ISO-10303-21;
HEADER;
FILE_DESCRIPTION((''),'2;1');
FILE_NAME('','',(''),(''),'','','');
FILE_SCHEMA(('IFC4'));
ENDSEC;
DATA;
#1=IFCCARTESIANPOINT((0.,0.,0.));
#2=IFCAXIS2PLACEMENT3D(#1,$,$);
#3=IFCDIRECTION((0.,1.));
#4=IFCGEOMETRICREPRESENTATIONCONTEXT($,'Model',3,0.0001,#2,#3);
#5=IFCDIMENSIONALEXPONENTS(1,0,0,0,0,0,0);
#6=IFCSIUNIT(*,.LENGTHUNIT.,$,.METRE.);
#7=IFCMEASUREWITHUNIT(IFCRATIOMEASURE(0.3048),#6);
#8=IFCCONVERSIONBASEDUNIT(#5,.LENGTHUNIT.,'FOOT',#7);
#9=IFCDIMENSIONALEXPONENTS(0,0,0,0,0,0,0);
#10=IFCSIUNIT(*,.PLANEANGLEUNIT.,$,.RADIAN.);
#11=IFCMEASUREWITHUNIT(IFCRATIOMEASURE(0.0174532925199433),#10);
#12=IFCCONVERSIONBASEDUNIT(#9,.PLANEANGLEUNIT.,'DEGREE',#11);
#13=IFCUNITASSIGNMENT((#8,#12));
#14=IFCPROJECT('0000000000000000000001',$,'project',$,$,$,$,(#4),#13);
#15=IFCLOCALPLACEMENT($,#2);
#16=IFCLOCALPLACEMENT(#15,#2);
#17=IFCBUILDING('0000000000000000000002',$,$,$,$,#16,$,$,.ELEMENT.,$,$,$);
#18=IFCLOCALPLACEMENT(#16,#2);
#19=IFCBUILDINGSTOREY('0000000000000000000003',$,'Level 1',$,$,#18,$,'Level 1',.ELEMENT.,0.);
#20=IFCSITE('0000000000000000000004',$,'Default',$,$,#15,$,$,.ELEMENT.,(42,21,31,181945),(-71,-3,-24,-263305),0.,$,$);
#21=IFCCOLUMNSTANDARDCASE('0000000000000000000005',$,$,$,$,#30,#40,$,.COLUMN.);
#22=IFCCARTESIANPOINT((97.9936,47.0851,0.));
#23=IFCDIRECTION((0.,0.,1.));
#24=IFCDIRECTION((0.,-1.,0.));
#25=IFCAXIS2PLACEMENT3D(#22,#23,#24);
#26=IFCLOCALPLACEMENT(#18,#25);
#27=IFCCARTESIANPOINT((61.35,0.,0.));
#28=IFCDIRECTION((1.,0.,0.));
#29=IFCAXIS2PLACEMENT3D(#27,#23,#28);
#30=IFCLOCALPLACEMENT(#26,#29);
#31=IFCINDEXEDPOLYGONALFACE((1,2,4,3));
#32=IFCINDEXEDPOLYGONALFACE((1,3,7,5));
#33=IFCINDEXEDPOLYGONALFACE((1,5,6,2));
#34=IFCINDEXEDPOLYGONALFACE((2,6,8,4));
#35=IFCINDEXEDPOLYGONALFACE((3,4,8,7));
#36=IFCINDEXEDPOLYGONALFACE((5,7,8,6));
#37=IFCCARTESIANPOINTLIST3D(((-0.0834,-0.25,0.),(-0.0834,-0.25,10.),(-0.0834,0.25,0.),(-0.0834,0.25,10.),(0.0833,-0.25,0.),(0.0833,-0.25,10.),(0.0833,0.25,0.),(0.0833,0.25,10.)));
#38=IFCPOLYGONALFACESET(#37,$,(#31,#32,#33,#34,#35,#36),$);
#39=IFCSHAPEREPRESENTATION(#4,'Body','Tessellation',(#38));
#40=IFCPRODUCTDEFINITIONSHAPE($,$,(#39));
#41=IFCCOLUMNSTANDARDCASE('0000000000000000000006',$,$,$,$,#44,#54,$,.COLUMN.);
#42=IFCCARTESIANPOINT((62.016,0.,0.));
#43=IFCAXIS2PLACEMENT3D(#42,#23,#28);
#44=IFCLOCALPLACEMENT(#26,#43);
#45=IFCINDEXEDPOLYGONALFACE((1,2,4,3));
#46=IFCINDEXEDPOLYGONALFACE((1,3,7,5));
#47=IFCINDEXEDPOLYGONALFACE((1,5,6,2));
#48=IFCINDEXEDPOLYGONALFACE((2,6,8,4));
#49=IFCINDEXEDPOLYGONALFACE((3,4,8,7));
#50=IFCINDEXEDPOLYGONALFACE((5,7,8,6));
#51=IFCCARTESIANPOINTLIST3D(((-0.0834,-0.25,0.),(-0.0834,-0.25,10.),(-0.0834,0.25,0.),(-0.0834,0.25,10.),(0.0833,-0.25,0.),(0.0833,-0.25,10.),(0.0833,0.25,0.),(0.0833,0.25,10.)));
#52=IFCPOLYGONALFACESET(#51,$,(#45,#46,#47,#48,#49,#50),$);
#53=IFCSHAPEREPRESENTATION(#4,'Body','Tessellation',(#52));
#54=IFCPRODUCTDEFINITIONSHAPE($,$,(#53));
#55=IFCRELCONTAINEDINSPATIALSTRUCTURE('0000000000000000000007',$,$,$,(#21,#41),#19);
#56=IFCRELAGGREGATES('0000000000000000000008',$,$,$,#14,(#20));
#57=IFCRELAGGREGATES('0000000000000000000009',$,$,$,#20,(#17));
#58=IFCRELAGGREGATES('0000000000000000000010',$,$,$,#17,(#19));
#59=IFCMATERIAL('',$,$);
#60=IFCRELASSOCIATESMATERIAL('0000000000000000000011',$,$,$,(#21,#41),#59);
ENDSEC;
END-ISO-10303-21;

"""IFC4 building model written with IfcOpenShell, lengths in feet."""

from ifc_helpers import new_model, entity, si_unit, converted_unit, direction, frame, origin, place, context, project, spatial, rectangle, extrude, material, element, save


model = new_model("IFC4")

# Units and contexts
model_context = context("Model", 3, precision=0.0001, world=origin(), true_north=direction((0.0, 1.0)))
ifc_project = project(units=[converted_unit("LENGTHUNIT", "FOOT", entity("IfcRatioMeasure", 0.3048), si_unit("LENGTHUNIT", "METRE"), dimensions=[1, 0, 0, 0, 0, 0, 0]), converted_unit("PLANEANGLEUNIT", "DEGREE", entity("IfcRatioMeasure", 0.0174532925199433), si_unit("PLANEANGLEUNIT", "RADIAN"), dimensions=[0, 0, 0, 0, 0, 0, 0])], contexts=[model_context])

# Site, building, storey
site_placement = place(None, origin())
site = spatial("IfcSite", under=ifc_project, at=site_placement, Name="Default", CompositionType="ELEMENT", RefLatitude=(42, 21, 31, 181945), RefLongitude=(-71, -3, -24, -263305), RefElevation=0.0)
building_placement = place(site_placement, origin())
building = spatial("IfcBuilding", under=site, at=building_placement, CompositionType="ELEMENT")
storey_placement = place(building_placement, origin())
storey = spatial("IfcBuildingStorey", under=building, at=storey_placement, Name="Level 1", LongName="Level 1", CompositionType="ELEMENT", Elevation=0.0)

# Columns
ifc_material_1 = material(Name="")
placement = place(storey_placement, frame((97.9936, 47.0851, 0.0), z_axis=(0.0, 0.0, 1.0), x_axis=(0.0, -1.0, 0.0)))
for number, where, z_axis, x_axis in (
    (1, (61.35, 0.0, 0.0), (0.0, 0.0, 1.0), (1.0, 0.0, 0.0)),
    (2, (62.016, 0.0, 0.0), (0.0, 0.0, 1.0), (1.0, 0.0, 0.0)),
):
    element("IfcColumnStandardCase", number, at=place(placement, frame(where, z_axis=z_axis, x_axis=x_axis)), inside=storey, material=ifc_material_1, PredefinedType="COLUMN", context=model_context, shape_type="SweptSolid", body=[
        extrude(rectangle(XDim=0.1667, YDim=0.5), origin(), (0.0, 0.0, 1.0), 10.0),
    ])

save(model, "model.ifc")
